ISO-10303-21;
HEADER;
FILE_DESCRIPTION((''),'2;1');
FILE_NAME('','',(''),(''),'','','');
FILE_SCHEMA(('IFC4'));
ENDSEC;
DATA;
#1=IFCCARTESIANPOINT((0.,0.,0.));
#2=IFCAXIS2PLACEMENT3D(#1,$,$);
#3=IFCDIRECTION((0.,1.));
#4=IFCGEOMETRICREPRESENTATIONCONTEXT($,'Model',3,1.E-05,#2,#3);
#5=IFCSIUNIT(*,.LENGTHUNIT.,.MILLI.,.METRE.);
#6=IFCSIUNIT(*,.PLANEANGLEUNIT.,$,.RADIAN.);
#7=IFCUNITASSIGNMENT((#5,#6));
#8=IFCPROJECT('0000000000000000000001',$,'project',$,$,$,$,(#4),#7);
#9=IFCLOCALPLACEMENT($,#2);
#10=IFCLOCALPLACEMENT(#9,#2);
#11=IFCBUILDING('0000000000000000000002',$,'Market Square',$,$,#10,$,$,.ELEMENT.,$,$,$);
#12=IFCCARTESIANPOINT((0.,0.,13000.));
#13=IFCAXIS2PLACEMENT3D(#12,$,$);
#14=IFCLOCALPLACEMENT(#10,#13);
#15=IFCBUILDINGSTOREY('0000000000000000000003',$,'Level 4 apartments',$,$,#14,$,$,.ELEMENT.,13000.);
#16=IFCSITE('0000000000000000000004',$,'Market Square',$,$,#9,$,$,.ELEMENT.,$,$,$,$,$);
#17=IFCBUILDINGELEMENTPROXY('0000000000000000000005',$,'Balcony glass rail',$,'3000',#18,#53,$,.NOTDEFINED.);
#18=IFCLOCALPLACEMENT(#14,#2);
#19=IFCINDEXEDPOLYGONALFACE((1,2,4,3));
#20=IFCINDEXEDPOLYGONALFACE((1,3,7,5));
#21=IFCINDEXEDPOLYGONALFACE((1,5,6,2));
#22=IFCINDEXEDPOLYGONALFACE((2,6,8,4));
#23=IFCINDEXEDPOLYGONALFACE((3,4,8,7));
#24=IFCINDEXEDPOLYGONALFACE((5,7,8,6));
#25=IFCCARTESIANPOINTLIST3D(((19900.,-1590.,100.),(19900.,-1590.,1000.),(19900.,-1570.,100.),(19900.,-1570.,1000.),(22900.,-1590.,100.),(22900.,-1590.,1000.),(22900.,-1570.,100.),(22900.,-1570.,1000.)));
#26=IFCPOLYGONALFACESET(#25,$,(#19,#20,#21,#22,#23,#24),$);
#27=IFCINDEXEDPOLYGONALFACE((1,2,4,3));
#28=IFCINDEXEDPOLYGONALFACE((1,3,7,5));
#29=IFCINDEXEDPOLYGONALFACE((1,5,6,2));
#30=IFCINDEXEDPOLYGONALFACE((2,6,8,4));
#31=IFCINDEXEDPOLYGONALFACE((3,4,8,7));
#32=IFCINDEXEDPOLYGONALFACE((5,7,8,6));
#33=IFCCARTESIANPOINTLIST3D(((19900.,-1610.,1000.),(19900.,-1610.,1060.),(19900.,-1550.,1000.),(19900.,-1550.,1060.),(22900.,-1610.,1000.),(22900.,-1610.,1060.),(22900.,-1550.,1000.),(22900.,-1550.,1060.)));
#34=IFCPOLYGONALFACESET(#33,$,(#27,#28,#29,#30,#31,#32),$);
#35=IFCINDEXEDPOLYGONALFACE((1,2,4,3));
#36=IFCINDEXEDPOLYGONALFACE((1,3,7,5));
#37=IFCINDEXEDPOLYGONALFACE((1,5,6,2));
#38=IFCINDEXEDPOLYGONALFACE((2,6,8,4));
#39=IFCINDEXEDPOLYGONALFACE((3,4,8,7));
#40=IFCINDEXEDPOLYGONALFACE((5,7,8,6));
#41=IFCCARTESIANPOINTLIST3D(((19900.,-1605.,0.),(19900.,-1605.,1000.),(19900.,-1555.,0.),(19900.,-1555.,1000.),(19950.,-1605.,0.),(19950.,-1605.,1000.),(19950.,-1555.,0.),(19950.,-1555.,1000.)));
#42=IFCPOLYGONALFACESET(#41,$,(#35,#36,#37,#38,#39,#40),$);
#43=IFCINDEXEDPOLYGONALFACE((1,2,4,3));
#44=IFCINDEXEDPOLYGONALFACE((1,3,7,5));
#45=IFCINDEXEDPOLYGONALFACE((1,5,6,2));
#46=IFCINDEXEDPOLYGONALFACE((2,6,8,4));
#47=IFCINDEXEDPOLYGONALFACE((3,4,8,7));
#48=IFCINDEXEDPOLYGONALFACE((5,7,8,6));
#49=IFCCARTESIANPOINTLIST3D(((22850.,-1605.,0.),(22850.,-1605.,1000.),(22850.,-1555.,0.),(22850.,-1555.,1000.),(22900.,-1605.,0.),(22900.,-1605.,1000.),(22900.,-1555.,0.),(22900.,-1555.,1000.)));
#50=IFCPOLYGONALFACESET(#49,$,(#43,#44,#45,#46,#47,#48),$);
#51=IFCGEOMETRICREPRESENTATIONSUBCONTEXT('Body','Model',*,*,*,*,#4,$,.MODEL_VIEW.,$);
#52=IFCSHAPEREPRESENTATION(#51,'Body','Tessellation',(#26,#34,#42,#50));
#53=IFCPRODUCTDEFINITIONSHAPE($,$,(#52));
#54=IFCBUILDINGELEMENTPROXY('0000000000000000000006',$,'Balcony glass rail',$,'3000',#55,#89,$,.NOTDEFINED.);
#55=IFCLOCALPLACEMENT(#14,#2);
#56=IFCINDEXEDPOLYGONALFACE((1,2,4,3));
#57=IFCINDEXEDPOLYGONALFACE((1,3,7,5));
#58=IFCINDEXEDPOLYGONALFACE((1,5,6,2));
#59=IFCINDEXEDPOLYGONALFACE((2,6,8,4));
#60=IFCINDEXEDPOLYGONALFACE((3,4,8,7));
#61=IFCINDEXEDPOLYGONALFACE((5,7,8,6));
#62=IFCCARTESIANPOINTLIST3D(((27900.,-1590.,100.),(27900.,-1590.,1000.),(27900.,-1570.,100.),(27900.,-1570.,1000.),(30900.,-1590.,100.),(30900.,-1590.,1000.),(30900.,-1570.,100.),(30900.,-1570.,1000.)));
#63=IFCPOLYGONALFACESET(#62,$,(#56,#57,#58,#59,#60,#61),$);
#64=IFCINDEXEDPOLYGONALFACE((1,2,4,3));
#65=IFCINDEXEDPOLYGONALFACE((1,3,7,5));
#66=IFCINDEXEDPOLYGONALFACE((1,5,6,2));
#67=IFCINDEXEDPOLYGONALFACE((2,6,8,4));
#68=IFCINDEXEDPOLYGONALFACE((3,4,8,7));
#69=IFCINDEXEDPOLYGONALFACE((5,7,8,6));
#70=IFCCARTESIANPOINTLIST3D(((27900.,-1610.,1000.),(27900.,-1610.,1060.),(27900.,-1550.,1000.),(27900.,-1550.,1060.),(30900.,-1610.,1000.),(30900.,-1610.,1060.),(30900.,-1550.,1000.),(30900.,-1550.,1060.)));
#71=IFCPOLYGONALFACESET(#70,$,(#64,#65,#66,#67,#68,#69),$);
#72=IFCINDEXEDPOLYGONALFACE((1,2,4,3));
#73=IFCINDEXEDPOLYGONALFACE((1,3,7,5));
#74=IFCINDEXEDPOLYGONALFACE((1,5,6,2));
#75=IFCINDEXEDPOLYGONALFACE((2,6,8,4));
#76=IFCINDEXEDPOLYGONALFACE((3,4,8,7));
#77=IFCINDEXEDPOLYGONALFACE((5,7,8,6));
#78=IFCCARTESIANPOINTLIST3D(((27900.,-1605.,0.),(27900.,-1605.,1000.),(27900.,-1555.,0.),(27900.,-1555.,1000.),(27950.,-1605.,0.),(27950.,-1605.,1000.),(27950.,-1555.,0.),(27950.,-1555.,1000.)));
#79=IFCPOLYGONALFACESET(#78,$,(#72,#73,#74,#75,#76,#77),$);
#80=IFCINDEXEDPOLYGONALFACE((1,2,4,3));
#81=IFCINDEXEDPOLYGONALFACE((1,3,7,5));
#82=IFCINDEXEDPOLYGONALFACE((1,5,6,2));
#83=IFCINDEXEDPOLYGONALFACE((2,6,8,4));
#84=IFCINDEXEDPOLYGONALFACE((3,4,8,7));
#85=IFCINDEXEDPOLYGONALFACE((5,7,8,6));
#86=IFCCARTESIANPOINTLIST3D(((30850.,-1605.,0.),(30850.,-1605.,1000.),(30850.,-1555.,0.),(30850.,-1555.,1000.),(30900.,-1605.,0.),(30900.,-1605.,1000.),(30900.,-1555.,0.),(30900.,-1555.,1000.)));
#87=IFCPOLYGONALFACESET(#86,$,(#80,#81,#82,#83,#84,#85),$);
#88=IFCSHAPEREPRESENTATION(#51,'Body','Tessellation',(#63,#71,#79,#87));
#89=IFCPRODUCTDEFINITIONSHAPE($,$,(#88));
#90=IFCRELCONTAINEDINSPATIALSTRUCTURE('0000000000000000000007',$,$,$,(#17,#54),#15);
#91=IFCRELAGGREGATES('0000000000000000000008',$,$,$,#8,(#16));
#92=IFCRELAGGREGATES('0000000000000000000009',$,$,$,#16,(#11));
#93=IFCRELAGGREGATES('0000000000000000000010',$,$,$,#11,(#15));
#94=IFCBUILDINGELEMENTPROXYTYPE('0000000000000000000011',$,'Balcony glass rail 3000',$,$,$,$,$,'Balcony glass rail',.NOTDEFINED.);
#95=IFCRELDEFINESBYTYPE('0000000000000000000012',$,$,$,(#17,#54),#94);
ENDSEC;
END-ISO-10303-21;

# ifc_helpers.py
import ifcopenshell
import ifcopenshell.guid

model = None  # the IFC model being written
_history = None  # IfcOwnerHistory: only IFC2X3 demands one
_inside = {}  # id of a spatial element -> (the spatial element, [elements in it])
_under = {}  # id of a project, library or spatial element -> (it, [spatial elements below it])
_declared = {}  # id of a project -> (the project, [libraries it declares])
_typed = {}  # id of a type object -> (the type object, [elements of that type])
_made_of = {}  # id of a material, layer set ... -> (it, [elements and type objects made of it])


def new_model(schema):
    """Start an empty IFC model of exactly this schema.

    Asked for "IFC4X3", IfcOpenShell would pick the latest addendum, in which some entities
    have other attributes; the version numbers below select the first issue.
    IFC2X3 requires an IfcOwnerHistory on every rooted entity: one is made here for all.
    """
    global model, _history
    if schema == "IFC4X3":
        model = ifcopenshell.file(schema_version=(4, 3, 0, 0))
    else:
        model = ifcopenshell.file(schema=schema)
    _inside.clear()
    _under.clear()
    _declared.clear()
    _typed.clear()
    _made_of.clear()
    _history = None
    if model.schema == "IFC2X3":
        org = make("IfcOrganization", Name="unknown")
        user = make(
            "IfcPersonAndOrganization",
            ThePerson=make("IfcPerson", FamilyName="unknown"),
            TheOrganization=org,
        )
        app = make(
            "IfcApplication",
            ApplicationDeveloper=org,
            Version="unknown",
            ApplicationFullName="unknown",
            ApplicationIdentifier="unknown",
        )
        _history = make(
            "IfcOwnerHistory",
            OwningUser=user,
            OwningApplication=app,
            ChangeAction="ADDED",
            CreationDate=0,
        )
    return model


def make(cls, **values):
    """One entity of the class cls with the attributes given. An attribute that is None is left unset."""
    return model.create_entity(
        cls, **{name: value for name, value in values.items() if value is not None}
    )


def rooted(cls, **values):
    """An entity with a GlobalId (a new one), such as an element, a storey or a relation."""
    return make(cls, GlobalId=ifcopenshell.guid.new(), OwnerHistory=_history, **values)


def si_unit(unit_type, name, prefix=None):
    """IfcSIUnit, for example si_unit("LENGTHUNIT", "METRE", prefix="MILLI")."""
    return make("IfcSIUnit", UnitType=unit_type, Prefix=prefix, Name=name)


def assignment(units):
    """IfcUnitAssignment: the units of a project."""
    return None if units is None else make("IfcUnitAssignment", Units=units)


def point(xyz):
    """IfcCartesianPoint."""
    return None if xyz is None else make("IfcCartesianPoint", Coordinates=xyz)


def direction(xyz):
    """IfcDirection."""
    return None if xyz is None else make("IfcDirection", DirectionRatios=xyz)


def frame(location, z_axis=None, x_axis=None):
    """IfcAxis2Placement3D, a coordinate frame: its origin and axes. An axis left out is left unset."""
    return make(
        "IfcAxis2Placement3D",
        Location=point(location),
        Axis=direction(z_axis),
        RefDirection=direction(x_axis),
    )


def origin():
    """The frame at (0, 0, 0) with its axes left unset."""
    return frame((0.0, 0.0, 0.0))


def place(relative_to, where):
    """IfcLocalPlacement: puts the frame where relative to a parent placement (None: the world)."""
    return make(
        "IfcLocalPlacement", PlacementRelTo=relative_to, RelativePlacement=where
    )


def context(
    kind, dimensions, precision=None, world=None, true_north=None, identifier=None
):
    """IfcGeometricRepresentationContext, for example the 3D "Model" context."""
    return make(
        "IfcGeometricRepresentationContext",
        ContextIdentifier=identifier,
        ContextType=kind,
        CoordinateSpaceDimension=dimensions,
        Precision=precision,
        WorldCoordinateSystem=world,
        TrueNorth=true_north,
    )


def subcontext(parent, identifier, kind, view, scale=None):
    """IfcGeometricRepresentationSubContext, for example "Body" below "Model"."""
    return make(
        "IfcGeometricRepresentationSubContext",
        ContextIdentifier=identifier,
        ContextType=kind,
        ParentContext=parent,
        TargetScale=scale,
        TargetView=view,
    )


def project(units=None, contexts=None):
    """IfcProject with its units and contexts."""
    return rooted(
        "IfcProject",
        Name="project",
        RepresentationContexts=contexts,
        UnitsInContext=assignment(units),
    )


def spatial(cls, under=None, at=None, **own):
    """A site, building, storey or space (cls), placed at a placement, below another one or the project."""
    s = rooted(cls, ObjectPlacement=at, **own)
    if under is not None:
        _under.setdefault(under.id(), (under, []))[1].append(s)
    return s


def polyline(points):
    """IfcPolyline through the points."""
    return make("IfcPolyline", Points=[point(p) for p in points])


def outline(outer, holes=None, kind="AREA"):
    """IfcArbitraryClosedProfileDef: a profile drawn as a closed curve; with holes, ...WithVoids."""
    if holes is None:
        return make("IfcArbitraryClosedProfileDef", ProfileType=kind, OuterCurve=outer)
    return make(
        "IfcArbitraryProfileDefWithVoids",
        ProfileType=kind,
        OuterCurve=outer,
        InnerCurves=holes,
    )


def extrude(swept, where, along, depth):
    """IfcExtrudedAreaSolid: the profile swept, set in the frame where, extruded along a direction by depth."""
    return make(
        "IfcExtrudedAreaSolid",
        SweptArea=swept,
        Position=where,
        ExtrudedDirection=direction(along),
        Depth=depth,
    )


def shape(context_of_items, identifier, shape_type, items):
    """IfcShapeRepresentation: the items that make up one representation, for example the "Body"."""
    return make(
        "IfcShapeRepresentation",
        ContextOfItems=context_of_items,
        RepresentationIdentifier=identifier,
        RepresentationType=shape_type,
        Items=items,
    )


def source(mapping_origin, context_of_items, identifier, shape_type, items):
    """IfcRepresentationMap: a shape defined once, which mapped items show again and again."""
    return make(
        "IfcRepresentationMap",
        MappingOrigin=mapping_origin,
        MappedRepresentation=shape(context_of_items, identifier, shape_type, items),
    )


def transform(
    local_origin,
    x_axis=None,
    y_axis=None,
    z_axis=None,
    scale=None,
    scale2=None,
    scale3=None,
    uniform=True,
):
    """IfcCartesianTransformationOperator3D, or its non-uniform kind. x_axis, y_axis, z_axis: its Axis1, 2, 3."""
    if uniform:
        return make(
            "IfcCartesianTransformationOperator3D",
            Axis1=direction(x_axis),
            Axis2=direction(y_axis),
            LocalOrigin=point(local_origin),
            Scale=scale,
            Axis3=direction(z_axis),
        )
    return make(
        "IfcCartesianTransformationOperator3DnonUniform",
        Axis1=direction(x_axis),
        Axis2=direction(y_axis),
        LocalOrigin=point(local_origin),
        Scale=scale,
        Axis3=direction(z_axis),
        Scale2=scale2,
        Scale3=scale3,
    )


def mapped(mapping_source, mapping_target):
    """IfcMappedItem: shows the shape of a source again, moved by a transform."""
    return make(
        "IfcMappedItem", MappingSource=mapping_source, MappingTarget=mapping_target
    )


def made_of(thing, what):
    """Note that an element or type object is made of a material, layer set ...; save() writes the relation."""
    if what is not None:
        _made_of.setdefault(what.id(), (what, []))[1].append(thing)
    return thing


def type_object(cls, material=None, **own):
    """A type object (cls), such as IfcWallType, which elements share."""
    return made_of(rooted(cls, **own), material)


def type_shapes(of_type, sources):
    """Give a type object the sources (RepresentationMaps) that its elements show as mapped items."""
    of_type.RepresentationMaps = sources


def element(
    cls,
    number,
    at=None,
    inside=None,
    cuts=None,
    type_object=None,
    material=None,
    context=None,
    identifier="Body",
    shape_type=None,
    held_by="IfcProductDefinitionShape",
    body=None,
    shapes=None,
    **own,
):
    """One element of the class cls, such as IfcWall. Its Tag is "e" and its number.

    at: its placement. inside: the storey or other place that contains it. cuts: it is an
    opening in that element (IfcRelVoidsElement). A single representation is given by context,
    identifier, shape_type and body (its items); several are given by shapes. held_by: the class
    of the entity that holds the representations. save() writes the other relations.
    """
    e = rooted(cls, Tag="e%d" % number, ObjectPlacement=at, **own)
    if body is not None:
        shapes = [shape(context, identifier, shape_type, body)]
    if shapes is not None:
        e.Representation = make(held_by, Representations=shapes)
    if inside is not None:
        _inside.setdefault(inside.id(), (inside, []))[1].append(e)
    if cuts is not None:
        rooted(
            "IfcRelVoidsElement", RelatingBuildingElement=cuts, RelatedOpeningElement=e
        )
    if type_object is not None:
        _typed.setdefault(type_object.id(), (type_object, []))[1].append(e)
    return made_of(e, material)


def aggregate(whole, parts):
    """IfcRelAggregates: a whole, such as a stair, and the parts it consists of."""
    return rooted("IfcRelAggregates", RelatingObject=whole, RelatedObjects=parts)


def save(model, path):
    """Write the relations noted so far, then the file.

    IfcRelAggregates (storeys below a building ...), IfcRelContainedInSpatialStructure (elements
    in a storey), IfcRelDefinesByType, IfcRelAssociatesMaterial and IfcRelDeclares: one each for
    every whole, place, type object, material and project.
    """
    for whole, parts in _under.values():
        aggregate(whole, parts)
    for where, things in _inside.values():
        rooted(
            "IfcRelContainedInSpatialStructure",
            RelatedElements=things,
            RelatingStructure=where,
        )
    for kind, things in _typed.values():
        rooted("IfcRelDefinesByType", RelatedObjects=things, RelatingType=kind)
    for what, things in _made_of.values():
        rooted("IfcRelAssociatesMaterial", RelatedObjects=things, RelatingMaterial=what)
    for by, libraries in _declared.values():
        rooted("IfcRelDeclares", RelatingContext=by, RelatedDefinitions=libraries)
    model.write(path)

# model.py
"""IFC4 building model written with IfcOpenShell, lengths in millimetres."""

from ifc_helpers import new_model, si_unit, direction, frame, origin, place, context, subcontext, project, spatial, polyline, outline, extrude, source, transform, mapped, type_object, type_shapes, element, save


model = new_model("IFC4")

# Units and contexts
model_context = context("Model", 3, precision=1e-05, world=origin(), true_north=direction((0.0, 1.0)))
body_context = subcontext(model_context, "Body", "Model", "MODEL_VIEW")
ifc_project = project(units=[si_unit("LENGTHUNIT", "METRE", prefix="MILLI"), si_unit("PLANEANGLEUNIT", "RADIAN")], contexts=[model_context])

# Site, building, storey
site_placement = place(None, origin())
site = spatial("IfcSite", under=ifc_project, at=site_placement, Name="Market Square", CompositionType="ELEMENT")
building_placement = place(site_placement, origin())
building = spatial("IfcBuilding", under=site, at=building_placement, Name="Market Square", CompositionType="ELEMENT")
storey_placement = place(building_placement, frame((0.0, 0.0, 13000.0)))
storey = spatial("IfcBuildingStorey", under=building, at=storey_placement, Name="Level 4 apartments", CompositionType="ELEMENT", Elevation=13000.0)

# Building element proxies
building_element_proxy_type = type_object("IfcBuildingElementProxyType", Name="Balcony glass rail 3000", ElementType="Balcony glass rail", PredefinedType="NOTDEFINED")
shared_shape = source(origin(), body_context, "Body", "SweptSolid", [
    extrude(outline(polyline([(0.0, -10.0), (3000.0, -10.0), (3000.0, 10.0), (0.0, 10.0), (0.0, -10.0)])), frame((0.0, 0.0, 100.0)), (0.0, 0.0, 1.0), 900.0),
    extrude(outline(polyline([(0.0, -30.0), (3000.0, -30.0), (3000.0, 30.0), (0.0, 30.0), (0.0, -30.0)])), frame((0.0, 0.0, 1000.0)), (0.0, 0.0, 1.0), 60.0),
    extrude(outline(polyline([(0.0, -25.0), (50.0, -25.0), (50.0, 25.0), (0.0, 25.0), (0.0, -25.0)])), origin(), (0.0, 0.0, 1.0), 1000.0),
    extrude(outline(polyline([(2950.0, -25.0), (3000.0, -25.0), (3000.0, 25.0), (2950.0, 25.0), (2950.0, -25.0)])), origin(), (0.0, 0.0, 1.0), 1000.0),
])
type_shapes(building_element_proxy_type, [shared_shape])
for number, where, z_axis, x_axis, name in (
    (1, (19900.0, -1580.0, 0.0), (0.0, 0.0, 1.0), (1.0, 0.0, 0.0), "Balcony glass rail"),
    (2, (27900.0, -1580.0, 0.0), (0.0, 0.0, 1.0), (1.0, 0.0, 0.0), "Balcony glass rail"),
):
    element("IfcBuildingElementProxy", number, at=place(storey_placement, frame(where, z_axis=z_axis, x_axis=x_axis)), inside=storey, type_object=building_element_proxy_type, Name=name, ObjectType="3000", PredefinedType="NOTDEFINED", context=body_context, shape_type="MappedRepresentation", body=[
        mapped(shared_shape, transform((0.0, 0.0, 0.0))),
    ])

save(model, "model.ifc")
